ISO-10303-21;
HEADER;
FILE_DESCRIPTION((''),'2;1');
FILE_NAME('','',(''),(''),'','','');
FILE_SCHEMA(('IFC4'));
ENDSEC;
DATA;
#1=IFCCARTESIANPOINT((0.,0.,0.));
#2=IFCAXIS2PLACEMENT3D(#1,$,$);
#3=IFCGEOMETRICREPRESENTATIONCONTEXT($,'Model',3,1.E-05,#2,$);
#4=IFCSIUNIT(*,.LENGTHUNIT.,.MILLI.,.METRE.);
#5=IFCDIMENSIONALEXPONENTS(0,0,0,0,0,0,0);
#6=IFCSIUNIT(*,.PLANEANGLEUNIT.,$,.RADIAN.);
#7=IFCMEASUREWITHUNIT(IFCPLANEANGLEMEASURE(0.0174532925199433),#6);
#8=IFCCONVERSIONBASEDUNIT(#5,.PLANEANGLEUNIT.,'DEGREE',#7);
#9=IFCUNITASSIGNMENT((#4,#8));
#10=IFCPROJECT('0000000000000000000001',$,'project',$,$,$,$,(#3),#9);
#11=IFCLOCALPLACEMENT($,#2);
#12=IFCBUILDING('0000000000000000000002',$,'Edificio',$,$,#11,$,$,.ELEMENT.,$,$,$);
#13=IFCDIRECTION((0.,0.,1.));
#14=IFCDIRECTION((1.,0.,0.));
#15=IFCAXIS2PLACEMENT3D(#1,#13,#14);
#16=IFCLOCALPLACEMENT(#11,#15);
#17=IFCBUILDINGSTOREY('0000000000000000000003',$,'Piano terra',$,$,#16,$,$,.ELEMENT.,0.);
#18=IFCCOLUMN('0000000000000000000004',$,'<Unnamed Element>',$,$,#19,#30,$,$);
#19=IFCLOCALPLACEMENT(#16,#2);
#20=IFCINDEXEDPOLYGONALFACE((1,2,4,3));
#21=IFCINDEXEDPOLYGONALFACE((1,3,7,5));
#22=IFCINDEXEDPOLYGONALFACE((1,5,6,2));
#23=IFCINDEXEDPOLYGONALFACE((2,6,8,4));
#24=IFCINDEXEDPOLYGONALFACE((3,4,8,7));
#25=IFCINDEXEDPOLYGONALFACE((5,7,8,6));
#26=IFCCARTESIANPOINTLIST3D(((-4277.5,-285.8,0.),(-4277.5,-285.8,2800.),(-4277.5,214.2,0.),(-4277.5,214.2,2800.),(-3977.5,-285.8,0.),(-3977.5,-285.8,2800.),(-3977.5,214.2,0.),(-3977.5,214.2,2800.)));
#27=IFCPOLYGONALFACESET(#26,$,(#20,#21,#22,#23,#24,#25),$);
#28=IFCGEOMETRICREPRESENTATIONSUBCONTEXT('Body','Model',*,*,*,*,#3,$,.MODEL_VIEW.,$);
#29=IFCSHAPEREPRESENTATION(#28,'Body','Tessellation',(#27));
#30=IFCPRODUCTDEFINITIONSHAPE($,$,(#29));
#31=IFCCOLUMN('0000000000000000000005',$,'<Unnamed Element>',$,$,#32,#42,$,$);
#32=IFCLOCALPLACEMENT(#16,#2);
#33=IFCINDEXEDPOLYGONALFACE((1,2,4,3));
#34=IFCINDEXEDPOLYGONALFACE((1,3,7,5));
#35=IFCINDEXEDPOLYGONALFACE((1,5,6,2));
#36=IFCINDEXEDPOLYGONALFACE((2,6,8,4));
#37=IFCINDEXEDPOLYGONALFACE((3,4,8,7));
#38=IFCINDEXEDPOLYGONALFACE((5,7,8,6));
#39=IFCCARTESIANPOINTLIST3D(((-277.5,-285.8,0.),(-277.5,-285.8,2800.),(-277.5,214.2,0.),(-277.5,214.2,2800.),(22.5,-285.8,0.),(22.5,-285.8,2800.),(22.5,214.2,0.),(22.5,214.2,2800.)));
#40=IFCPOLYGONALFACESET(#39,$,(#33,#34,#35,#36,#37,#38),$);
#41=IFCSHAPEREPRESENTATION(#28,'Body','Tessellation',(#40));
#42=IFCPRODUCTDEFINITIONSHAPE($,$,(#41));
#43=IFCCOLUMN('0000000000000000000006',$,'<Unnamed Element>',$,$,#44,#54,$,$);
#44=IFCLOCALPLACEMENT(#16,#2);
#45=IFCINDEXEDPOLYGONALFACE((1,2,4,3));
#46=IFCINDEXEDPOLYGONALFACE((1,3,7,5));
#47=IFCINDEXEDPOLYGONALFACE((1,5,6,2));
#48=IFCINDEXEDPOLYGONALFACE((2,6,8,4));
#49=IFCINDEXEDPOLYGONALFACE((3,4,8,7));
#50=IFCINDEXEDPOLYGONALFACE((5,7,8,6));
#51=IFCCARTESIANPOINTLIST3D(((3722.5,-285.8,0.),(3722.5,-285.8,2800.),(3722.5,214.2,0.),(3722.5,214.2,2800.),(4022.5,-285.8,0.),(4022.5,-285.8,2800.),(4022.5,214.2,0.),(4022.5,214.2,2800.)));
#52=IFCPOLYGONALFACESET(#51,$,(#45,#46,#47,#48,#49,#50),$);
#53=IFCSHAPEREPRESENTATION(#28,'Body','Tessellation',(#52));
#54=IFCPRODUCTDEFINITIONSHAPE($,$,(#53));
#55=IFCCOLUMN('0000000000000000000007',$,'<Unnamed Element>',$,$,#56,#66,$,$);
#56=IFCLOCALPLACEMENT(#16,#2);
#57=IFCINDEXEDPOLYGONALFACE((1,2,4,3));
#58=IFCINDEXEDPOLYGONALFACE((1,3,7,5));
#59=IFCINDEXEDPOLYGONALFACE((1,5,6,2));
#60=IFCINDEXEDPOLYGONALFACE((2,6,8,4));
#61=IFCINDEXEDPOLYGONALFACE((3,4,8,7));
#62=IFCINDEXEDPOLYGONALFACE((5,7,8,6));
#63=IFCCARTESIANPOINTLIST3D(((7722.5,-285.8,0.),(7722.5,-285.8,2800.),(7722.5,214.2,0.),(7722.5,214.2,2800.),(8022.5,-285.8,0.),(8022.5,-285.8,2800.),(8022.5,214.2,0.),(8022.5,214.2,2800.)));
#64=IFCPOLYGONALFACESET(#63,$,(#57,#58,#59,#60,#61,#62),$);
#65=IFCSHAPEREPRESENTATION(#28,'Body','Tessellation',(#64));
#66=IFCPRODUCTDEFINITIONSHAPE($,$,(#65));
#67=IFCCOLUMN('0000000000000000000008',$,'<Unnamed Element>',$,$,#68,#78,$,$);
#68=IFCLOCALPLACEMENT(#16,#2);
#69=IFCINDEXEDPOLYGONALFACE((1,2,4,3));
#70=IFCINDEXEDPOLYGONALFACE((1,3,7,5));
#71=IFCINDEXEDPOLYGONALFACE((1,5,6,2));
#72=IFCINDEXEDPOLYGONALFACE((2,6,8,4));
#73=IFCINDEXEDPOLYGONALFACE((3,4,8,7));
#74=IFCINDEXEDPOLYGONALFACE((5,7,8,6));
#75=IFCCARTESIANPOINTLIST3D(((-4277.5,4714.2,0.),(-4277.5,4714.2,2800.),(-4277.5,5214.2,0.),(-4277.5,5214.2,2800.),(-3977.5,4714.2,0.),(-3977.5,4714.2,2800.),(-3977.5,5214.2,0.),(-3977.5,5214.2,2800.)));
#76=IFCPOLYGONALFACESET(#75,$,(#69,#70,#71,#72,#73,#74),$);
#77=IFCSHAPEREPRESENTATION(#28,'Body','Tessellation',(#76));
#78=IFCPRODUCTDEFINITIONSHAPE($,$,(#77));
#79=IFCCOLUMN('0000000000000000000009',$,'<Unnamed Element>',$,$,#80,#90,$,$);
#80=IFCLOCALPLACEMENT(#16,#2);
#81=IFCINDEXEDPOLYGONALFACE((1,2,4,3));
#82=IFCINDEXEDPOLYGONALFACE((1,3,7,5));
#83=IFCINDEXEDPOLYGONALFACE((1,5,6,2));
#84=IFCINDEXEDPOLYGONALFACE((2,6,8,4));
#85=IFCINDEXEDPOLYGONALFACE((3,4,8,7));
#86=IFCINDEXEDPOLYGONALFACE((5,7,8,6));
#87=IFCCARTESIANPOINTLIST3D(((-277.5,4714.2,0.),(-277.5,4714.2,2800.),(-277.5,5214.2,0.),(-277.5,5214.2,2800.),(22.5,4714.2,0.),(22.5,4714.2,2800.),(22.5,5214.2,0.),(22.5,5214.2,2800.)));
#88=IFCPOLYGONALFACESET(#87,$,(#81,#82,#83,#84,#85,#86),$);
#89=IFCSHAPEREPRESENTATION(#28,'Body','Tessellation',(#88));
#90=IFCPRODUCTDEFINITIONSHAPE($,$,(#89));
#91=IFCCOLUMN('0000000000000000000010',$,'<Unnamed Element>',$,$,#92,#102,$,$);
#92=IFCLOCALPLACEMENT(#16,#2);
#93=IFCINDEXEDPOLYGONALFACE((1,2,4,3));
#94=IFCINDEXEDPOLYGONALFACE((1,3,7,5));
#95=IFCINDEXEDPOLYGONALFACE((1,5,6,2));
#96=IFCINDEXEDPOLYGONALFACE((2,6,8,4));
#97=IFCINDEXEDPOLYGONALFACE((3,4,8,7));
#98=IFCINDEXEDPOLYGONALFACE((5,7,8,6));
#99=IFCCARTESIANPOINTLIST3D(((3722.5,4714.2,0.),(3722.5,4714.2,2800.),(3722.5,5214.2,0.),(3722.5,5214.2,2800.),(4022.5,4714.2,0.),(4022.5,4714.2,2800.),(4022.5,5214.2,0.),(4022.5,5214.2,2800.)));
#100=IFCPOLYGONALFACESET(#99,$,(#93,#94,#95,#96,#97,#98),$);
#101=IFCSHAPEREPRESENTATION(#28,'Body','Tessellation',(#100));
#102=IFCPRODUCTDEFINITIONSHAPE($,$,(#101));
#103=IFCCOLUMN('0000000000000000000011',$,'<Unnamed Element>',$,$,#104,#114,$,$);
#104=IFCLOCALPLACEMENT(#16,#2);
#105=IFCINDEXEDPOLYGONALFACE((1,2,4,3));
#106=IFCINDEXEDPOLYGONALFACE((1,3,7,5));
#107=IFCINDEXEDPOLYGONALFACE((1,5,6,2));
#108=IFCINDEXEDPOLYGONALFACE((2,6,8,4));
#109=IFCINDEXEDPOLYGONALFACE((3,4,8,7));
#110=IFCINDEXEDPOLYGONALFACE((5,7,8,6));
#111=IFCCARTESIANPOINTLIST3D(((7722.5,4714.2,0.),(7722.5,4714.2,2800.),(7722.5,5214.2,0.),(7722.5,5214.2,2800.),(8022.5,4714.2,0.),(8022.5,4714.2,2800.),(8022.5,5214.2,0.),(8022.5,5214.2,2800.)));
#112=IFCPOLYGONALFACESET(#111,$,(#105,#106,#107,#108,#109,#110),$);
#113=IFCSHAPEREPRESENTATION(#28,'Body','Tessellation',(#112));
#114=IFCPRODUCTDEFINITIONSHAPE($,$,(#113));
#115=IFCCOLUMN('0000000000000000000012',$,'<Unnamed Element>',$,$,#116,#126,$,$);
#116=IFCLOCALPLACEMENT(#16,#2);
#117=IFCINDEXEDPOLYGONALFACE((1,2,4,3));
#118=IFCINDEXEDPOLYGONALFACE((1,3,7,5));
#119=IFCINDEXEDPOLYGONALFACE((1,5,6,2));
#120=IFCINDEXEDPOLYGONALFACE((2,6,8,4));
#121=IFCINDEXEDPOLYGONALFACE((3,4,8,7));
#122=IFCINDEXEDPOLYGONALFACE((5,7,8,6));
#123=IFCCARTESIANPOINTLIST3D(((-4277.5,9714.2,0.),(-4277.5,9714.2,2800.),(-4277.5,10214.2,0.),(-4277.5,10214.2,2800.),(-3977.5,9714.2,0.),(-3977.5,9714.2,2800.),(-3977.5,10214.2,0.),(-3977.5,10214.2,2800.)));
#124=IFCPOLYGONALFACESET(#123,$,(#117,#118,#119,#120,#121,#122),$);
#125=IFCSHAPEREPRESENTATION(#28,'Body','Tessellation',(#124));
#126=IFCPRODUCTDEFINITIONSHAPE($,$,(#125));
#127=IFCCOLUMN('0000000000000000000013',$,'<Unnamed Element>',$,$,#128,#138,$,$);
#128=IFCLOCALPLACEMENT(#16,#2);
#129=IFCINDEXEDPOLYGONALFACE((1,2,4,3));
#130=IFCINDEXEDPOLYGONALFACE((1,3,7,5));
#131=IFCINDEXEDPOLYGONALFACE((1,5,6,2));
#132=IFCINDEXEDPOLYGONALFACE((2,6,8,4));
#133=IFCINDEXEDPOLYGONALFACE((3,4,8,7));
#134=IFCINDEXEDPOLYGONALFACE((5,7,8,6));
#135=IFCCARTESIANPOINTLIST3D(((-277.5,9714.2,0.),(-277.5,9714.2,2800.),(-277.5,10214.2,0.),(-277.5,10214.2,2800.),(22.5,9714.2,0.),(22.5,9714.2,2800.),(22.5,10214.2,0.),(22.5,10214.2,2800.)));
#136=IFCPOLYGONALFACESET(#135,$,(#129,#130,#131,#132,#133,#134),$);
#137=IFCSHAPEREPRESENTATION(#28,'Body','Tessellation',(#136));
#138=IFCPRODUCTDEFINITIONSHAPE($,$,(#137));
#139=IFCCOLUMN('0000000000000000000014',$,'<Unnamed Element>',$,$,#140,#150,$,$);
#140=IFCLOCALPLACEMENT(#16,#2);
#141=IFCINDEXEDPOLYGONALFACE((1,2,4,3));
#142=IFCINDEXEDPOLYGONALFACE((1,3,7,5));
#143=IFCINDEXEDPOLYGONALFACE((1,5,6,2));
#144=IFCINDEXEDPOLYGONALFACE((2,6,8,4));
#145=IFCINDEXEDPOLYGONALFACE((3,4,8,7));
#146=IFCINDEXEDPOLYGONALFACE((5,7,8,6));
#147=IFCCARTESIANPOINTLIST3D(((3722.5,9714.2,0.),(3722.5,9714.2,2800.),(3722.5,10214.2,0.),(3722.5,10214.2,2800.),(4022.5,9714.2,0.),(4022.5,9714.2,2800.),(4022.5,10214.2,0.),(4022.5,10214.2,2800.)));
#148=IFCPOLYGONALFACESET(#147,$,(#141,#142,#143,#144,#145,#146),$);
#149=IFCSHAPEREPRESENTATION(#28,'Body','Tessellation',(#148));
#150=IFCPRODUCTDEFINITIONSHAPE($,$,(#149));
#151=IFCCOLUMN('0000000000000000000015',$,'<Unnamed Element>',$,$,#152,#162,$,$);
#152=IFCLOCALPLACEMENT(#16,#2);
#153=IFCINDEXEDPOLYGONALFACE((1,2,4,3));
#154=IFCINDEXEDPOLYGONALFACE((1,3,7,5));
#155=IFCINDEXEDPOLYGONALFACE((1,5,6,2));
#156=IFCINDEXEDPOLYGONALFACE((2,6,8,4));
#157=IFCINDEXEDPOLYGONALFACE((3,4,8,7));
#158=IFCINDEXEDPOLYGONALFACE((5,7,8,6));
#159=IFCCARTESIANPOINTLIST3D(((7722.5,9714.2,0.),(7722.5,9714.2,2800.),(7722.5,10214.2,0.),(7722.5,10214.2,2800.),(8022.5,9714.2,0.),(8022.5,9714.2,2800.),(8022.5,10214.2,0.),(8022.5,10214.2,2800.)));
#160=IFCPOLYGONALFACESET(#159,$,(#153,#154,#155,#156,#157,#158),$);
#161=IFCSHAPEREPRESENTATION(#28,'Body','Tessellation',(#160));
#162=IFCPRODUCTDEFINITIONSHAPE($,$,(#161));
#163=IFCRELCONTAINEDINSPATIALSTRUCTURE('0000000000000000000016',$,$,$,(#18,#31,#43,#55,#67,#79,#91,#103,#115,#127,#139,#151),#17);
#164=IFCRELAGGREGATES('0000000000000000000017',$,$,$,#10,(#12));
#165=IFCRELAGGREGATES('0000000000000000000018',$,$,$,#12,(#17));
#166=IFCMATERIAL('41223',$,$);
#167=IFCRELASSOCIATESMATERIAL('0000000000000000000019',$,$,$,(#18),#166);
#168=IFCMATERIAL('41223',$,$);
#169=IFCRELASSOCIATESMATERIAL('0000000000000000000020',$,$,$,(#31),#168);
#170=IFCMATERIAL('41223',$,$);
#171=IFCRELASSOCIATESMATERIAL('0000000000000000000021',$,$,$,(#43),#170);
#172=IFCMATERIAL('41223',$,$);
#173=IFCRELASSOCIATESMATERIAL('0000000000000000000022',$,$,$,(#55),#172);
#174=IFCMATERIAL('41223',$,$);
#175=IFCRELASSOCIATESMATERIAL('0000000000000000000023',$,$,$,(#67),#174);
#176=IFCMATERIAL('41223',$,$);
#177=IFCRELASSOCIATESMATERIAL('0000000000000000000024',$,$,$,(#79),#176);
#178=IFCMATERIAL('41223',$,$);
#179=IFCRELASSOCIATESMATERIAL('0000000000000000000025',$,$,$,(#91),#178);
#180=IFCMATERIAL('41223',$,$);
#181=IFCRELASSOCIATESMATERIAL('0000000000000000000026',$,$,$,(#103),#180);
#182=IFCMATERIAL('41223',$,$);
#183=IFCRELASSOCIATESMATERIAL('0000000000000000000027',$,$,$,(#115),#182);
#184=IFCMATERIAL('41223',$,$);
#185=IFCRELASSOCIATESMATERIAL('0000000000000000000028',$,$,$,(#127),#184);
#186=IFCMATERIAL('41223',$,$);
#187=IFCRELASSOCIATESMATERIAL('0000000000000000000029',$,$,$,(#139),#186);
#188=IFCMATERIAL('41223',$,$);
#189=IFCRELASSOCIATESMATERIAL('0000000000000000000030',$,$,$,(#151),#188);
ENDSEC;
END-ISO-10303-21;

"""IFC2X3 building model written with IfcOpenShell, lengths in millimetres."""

from ifc_helpers import new_model, entity, si_unit, converted_unit, frame, frame_2d, origin, origin_with_axes, place, context, subcontext, project, spatial, rectangle, extrude, material, element, save


model = new_model("IFC2X3")

# Units and contexts
model_context = context("Model", 3, precision=1e-05, world=origin())
body_context = subcontext(model_context, "Body", "Model", "MODEL_VIEW")
ifc_project = project(units=[si_unit("LENGTHUNIT", "METRE", prefix="MILLI"), converted_unit("PLANEANGLEUNIT", "DEGREE", entity("IfcPlaneAngleMeasure", 0.0174532925199433), si_unit("PLANEANGLEUNIT", "RADIAN"), dimensions=[0, 0, 0, 0, 0, 0, 0])], contexts=[model_context])

# Building, storey
building_placement = place(None, origin())
building = spatial("IfcBuilding", under=ifc_project, at=building_placement, Name="Edificio", CompositionType="ELEMENT")
storey_placement = place(building_placement, origin_with_axes())
storey = spatial("IfcBuildingStorey", under=building, at=storey_placement, Name="Piano terra", CompositionType="ELEMENT", Elevation=0.0)

# Columns
ifc_material_1 = material(Name="41223")
column_1_placement = place(storey_placement, frame((-4277.5, -285.8, 0.0), z_axis=(0.0, 0.0, 1.0), x_axis=(1.0, 0.0, 0.0)))
element("IfcColumn", 1, at=column_1_placement, inside=storey, material=ifc_material_1, Name="<Unnamed Element>", context=body_context, shape_type="SweptSolid", body=[
    extrude(rectangle(XDim=300.0, YDim=500.0, at=frame_2d((150.0, 250.0), x_axis=(1.0, 0.0))), origin_with_axes(), (0.0, 0.0, 1.0), 2800.0),
])
ifc_material_2 = material(Name="41223")
column_2_placement = place(storey_placement, frame((-277.5, -285.8, 0.0), z_axis=(0.0, 0.0, 1.0), x_axis=(1.0, 0.0, 0.0)))
element("IfcColumn", 2, at=column_2_placement, inside=storey, material=ifc_material_2, Name="<Unnamed Element>", context=body_context, shape_type="SweptSolid", body=[
    extrude(rectangle(XDim=300.0, YDim=500.0, at=frame_2d((150.0, 250.0), x_axis=(1.0, 0.0))), origin_with_axes(), (0.0, 0.0, 1.0), 2800.0),
])
ifc_material_3 = material(Name="41223")
column_3_placement = place(storey_placement, frame((3722.5, -285.8, 0.0), z_axis=(0.0, 0.0, 1.0), x_axis=(1.0, 0.0, 0.0)))
element("IfcColumn", 3, at=column_3_placement, inside=storey, material=ifc_material_3, Name="<Unnamed Element>", context=body_context, shape_type="SweptSolid", body=[
    extrude(rectangle(XDim=300.0, YDim=500.0, at=frame_2d((150.0, 250.0), x_axis=(1.0, 0.0))), origin_with_axes(), (0.0, 0.0, 1.0), 2800.0),
])
ifc_material_4 = material(Name="41223")
column_4_placement = place(storey_placement, frame((7722.5, -285.8, 0.0), z_axis=(0.0, 0.0, 1.0), x_axis=(1.0, 0.0, 0.0)))
element("IfcColumn", 4, at=column_4_placement, inside=storey, material=ifc_material_4, Name="<Unnamed Element>", context=body_context, shape_type="SweptSolid", body=[
    extrude(rectangle(XDim=300.0, YDim=500.0, at=frame_2d((150.0, 250.0), x_axis=(1.0, 0.0))), origin_with_axes(), (0.0, 0.0, 1.0), 2800.0),
])
ifc_material_5 = material(Name="41223")
column_5_placement = place(storey_placement, frame((-4277.5, 4714.2, 0.0), z_axis=(0.0, 0.0, 1.0), x_axis=(1.0, 0.0, 0.0)))
element("IfcColumn", 5, at=column_5_placement, inside=storey, material=ifc_material_5, Name="<Unnamed Element>", context=body_context, shape_type="SweptSolid", body=[
    extrude(rectangle(XDim=300.0, YDim=500.0, at=frame_2d((150.0, 250.0), x_axis=(1.0, 0.0))), origin_with_axes(), (0.0, 0.0, 1.0), 2800.0),
])
ifc_material_6 = material(Name="41223")
column_6_placement = place(storey_placement, frame((-277.5, 4714.2, 0.0), z_axis=(0.0, 0.0, 1.0), x_axis=(1.0, 0.0, 0.0)))
element("IfcColumn", 6, at=column_6_placement, inside=storey, material=ifc_material_6, Name="<Unnamed Element>", context=body_context, shape_type="SweptSolid", body=[
    extrude(rectangle(XDim=300.0, YDim=500.0, at=frame_2d((150.0, 250.0), x_axis=(1.0, 0.0))), origin_with_axes(), (0.0, 0.0, 1.0), 2800.0),
])
ifc_material_7 = material(Name="41223")
column_7_placement = place(storey_placement, frame((3722.5, 4714.2, 0.0), z_axis=(0.0, 0.0, 1.0), x_axis=(1.0, 0.0, 0.0)))
element("IfcColumn", 7, at=column_7_placement, inside=storey, material=ifc_material_7, Name="<Unnamed Element>", context=body_context, shape_type="SweptSolid", body=[
    extrude(rectangle(XDim=300.0, YDim=500.0, at=frame_2d((150.0, 250.0), x_axis=(1.0, 0.0))), origin_with_axes(), (0.0, 0.0, 1.0), 2800.0),
])
ifc_material_8 = material(Name="41223")
column_8_placement = place(storey_placement, frame((7722.5, 4714.2, 0.0), z_axis=(0.0, 0.0, 1.0), x_axis=(1.0, 0.0, 0.0)))
element("IfcColumn", 8, at=column_8_placement, inside=storey, material=ifc_material_8, Name="<Unnamed Element>", context=body_context, shape_type="SweptSolid", body=[
    extrude(rectangle(XDim=300.0, YDim=500.0, at=frame_2d((150.0, 250.0), x_axis=(1.0, 0.0))), origin_with_axes(), (0.0, 0.0, 1.0), 2800.0),
])
ifc_material_9 = material(Name="41223")
column_9_placement = place(storey_placement, frame((-4277.5, 9714.2, 0.0), z_axis=(0.0, 0.0, 1.0), x_axis=(1.0, 0.0, 0.0)))
element("IfcColumn", 9, at=column_9_placement, inside=storey, material=ifc_material_9, Name="<Unnamed Element>", context=body_context, shape_type="SweptSolid", body=[
    extrude(rectangle(XDim=300.0, YDim=500.0, at=frame_2d((150.0, 250.0), x_axis=(1.0, 0.0))), origin_with_axes(), (0.0, 0.0, 1.0), 2800.0),
])
ifc_material_10 = material(Name="41223")
column_10_placement = place(storey_placement, frame((-277.5, 9714.2, 0.0), z_axis=(0.0, 0.0, 1.0), x_axis=(1.0, 0.0, 0.0)))
element("IfcColumn", 10, at=column_10_placement, inside=storey, material=ifc_material_10, Name="<Unnamed Element>", context=body_context, shape_type="SweptSolid", body=[
    extrude(rectangle(XDim=300.0, YDim=500.0, at=frame_2d((150.0, 250.0), x_axis=(1.0, 0.0))), origin_with_axes(), (0.0, 0.0, 1.0), 2800.0),
])
ifc_material_11 = material(Name="41223")
column_11_placement = place(storey_placement, frame((3722.5, 9714.2, 0.0), z_axis=(0.0, 0.0, 1.0), x_axis=(1.0, 0.0, 0.0)))
element("IfcColumn", 11, at=column_11_placement, inside=storey, material=ifc_material_11, Name="<Unnamed Element>", context=body_context, shape_type="SweptSolid", body=[
    extrude(rectangle(XDim=300.0, YDim=500.0, at=frame_2d((150.0, 250.0), x_axis=(1.0, 0.0))), origin_with_axes(), (0.0, 0.0, 1.0), 2800.0),
])
ifc_material_12 = material(Name="41223")
column_12_placement = place(storey_placement, frame((7722.5, 9714.2, 0.0), z_axis=(0.0, 0.0, 1.0), x_axis=(1.0, 0.0, 0.0)))
element("IfcColumn", 12, at=column_12_placement, inside=storey, material=ifc_material_12, Name="<Unnamed Element>", context=body_context, shape_type="SweptSolid", body=[
    extrude(rectangle(XDim=300.0, YDim=500.0, at=frame_2d((150.0, 250.0), x_axis=(1.0, 0.0))), origin_with_axes(), (0.0, 0.0, 1.0), 2800.0),
])

save(model, "model.ifc")
